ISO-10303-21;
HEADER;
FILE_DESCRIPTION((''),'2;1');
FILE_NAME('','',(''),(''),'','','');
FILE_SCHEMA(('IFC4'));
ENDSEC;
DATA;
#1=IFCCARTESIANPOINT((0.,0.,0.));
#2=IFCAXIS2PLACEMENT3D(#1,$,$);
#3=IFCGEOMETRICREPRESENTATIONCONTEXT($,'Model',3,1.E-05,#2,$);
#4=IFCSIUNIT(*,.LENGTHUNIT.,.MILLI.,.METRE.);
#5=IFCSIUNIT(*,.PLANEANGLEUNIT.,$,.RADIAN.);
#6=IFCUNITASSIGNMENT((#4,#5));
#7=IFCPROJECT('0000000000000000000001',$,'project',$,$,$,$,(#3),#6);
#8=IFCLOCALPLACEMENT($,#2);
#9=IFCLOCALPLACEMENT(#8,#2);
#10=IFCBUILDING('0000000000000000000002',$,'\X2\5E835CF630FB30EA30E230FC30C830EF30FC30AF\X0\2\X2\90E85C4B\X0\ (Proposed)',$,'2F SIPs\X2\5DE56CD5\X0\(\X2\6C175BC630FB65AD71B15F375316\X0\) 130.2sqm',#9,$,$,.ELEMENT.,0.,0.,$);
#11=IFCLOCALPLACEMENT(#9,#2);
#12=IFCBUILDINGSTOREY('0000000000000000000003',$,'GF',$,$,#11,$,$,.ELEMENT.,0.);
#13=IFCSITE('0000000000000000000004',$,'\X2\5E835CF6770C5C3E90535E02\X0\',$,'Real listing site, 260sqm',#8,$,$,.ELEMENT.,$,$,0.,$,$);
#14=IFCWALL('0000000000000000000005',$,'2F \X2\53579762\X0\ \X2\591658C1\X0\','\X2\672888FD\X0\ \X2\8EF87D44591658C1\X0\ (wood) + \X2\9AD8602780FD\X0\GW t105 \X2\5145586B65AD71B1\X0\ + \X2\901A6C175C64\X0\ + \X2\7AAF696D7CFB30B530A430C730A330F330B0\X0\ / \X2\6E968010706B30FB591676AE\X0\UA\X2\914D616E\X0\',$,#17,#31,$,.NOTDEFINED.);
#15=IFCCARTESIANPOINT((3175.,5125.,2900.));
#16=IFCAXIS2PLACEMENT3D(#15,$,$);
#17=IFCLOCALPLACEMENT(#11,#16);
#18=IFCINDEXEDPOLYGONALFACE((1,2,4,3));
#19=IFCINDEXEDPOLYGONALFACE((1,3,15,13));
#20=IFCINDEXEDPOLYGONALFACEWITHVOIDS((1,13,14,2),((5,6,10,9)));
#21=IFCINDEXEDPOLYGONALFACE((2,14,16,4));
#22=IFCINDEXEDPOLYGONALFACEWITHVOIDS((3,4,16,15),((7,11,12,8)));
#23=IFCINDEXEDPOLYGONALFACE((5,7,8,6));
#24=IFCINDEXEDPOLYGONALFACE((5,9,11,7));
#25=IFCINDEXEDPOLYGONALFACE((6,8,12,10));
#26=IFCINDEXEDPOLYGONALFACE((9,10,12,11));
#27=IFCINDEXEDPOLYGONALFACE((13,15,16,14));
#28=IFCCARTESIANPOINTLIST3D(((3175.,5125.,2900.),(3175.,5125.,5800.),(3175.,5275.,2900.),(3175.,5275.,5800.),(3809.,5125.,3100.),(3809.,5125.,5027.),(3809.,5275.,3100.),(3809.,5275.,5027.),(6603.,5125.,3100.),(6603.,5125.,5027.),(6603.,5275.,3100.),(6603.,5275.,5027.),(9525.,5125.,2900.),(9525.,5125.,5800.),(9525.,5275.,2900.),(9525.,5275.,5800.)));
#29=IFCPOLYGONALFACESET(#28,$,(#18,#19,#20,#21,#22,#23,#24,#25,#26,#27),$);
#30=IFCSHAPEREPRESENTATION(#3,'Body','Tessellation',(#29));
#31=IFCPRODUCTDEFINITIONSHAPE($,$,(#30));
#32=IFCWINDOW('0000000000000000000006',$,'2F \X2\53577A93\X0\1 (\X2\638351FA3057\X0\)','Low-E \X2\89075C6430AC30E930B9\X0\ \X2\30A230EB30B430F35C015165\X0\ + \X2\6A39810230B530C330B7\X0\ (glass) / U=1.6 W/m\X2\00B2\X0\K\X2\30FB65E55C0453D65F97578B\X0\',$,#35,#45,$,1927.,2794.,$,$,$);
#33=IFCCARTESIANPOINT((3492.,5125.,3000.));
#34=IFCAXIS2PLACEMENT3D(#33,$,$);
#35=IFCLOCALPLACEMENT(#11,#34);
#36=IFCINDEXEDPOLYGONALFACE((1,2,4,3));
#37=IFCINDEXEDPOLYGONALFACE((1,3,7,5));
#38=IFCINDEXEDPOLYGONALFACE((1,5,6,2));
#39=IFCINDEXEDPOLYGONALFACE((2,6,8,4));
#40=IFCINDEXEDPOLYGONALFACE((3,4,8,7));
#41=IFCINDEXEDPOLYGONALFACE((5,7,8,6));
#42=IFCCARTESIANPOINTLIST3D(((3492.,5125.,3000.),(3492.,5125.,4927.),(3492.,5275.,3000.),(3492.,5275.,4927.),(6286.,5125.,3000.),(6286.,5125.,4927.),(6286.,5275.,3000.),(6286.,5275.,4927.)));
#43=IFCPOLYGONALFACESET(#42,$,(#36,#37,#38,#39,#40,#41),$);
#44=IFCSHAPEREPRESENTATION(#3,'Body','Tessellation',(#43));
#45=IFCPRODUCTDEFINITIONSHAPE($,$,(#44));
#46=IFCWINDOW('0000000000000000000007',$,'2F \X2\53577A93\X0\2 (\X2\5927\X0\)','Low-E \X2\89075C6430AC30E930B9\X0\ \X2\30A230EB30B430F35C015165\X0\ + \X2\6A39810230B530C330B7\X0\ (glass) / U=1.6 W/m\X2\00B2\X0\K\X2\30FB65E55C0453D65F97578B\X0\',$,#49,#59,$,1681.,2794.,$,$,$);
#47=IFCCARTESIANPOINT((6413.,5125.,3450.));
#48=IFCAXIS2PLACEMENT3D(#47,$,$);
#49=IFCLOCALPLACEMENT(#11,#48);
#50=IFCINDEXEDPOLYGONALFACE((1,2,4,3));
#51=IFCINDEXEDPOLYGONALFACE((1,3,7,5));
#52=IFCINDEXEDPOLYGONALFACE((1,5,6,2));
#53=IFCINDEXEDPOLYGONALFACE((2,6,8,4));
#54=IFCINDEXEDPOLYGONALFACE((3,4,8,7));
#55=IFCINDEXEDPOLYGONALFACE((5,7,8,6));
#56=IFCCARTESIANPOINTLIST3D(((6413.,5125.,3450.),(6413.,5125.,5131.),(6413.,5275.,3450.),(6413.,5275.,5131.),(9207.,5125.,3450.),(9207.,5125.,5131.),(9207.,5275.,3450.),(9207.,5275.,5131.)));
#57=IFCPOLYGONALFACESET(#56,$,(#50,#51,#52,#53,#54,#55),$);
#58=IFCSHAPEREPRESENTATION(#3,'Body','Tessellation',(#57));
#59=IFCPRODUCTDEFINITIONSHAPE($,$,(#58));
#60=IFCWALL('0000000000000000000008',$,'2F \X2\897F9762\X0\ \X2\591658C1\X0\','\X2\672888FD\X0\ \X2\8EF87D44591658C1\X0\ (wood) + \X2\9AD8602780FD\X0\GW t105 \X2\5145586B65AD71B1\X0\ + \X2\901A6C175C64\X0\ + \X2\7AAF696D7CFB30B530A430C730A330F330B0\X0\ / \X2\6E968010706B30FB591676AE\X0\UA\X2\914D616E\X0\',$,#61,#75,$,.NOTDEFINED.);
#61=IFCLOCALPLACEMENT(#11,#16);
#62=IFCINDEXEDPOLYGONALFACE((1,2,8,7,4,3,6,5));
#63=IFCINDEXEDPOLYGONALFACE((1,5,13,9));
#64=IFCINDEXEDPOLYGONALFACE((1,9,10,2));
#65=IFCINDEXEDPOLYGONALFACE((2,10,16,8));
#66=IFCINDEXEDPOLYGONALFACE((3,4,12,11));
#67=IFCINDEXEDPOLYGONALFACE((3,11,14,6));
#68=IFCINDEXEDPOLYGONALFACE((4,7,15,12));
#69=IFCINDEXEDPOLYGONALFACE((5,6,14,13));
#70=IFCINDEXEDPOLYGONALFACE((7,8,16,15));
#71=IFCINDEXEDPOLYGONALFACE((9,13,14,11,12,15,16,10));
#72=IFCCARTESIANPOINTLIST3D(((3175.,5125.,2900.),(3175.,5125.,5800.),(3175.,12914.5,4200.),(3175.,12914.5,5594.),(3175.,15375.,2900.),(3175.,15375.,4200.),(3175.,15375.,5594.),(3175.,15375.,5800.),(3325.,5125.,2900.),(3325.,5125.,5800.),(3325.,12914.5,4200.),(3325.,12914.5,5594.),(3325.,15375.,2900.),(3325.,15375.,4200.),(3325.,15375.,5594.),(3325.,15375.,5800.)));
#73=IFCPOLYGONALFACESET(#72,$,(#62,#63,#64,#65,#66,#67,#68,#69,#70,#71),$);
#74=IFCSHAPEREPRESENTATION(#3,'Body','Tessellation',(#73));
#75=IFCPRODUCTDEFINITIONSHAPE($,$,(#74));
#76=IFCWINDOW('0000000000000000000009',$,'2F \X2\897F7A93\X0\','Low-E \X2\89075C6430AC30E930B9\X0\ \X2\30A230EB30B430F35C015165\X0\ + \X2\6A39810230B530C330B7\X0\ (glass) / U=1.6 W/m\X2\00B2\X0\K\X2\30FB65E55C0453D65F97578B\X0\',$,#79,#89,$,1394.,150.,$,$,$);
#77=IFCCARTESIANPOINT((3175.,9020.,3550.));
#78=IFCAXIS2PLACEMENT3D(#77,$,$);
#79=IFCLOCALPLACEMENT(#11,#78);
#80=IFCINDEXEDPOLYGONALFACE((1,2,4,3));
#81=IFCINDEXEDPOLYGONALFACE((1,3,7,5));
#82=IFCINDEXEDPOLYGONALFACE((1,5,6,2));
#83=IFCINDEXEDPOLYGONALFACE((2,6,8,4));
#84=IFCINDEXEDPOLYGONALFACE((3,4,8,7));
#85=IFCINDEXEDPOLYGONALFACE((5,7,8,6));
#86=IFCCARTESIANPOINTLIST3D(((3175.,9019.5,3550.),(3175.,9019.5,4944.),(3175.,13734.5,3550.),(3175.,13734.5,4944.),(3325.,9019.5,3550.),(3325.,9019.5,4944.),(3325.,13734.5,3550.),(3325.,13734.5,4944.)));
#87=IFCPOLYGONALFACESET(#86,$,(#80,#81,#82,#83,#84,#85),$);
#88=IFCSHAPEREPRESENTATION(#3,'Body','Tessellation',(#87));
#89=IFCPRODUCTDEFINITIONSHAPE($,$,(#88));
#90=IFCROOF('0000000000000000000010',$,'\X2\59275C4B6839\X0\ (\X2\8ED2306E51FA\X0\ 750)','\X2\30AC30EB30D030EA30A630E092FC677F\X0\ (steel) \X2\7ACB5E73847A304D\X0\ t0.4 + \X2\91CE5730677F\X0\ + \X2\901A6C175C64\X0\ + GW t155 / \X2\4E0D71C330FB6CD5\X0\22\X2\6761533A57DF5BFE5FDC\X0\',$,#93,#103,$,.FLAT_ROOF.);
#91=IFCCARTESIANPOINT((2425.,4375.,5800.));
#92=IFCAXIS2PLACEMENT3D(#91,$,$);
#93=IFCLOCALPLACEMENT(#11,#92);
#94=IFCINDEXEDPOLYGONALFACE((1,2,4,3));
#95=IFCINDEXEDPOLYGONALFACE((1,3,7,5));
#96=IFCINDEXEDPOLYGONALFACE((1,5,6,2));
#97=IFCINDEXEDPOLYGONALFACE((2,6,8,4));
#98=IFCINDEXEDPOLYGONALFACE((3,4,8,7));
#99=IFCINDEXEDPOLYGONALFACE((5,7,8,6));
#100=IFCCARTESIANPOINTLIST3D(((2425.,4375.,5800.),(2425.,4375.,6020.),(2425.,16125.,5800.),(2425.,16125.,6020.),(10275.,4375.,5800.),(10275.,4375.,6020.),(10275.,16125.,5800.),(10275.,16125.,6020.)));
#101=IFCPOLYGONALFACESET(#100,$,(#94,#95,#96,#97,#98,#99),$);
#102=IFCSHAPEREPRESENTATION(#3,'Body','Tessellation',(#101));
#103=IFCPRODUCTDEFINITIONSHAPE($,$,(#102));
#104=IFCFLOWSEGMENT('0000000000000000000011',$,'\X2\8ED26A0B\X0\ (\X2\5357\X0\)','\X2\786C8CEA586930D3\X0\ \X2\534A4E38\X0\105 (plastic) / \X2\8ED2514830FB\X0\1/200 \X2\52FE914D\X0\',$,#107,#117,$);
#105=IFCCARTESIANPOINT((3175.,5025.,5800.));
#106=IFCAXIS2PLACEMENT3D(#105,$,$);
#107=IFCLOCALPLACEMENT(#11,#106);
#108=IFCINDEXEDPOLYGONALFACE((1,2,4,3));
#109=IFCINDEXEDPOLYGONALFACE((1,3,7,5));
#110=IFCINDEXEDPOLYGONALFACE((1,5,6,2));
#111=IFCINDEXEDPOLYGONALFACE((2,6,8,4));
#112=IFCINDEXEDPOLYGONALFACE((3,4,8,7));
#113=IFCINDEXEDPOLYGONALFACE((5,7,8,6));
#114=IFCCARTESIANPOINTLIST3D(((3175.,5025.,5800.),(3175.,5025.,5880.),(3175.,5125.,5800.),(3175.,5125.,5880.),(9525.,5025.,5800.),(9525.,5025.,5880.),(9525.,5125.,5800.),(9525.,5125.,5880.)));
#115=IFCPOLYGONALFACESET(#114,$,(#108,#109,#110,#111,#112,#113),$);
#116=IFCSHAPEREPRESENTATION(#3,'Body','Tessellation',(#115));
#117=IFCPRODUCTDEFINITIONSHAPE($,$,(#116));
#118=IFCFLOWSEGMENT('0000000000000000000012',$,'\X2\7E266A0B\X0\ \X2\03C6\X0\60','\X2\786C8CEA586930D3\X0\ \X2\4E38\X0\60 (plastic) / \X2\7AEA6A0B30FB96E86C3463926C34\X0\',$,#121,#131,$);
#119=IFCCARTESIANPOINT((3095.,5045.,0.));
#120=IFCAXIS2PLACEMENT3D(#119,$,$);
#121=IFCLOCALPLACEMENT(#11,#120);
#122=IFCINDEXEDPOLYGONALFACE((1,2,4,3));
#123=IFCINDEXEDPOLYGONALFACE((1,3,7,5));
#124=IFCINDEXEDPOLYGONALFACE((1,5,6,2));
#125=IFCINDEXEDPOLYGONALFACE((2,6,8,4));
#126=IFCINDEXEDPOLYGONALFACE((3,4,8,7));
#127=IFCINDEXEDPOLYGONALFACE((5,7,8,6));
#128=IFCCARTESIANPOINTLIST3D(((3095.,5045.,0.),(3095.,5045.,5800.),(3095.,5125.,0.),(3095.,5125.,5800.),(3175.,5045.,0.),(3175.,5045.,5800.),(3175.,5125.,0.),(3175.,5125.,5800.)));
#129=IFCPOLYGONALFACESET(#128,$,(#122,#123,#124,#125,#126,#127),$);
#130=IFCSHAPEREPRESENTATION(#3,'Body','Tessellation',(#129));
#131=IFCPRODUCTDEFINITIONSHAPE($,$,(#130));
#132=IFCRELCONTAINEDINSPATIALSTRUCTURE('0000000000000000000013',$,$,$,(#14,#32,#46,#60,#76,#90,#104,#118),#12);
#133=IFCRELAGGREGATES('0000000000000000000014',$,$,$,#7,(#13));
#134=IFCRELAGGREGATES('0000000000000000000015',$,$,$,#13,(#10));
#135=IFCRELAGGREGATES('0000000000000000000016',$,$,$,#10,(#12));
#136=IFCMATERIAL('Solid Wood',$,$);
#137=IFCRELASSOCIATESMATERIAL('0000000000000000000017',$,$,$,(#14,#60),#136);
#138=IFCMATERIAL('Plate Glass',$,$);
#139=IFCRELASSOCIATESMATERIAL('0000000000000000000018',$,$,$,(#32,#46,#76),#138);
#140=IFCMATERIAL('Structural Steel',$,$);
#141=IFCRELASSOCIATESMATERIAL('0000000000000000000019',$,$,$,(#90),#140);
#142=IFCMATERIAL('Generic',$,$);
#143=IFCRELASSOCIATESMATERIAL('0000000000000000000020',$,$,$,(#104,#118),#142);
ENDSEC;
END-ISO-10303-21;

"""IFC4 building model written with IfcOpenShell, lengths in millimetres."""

from ifc_helpers import new_model, si_unit, frame, frame_2d, origin, place, context, project, spatial, rectangle, extrude, material, element, fill, save


model = new_model("IFC4")

# Units and contexts
model_context = context("Model", 3, precision=1e-05, world=origin())
ifc_project = project(units=[si_unit("LENGTHUNIT", "METRE", prefix="MILLI"), si_unit("PLANEANGLEUNIT", "RADIAN")], contexts=[model_context])

# Site, building, storey
site_placement = place(None, origin())
site = spatial("IfcSite", under=ifc_project, at=site_placement, Name="広島県尾道市", ObjectType="Real listing site, 260sqm", CompositionType="ELEMENT", RefElevation=0.0)
building_placement = place(site_placement, origin())
building = spatial("IfcBuilding", under=site, at=building_placement, Name="広島・リモートワーク2部屋 (Proposed)", ObjectType="2F SIPs工法(気密・断熱強化) 130.2sqm", CompositionType="ELEMENT", ElevationOfRefHeight=0.0, ElevationOfTerrain=0.0)
storey_placement = place(building_placement, origin())
storey = spatial("IfcBuildingStorey", under=building, at=storey_placement, Name="GF", CompositionType="ELEMENT", Elevation=0.0)

# Shared definitions
ifc_material_1 = material(Name="Solid Wood")

# Shared definitions
ifc_material_2 = material(Name="Plate Glass")

# Wall, openings, windows
wall_1_placement = place(storey_placement, frame((3175.0, 5125.0, 2900.0)))
wall_1 = element("IfcWall", 1, at=wall_1_placement, inside=storey, material=ifc_material_1, Name="2F 南面 外壁", Description="木製 軸組外壁 (wood) + 高性能GW t105 充填断熱 + 通気層 + 窯業系サイディング / 準耐火・外皮UA配慮", PredefinedType="NOTDEFINED", context=model_context, shape_type="SweptSolid", body=[
    extrude(rectangle(XDim=6350.0, YDim=150.0, at=frame_2d((3175.0, 75.0))), frame((3175.0, 5125.0, 2900.0)), (0.0, 0.0, 1.0), 2900.0),
])
opening_1_placement = place(storey_placement, frame((3492.0, 5125.0, 3000.0)))
opening_1 = element("IfcOpeningElement", 2, at=opening_1_placement, cuts=wall_1, PredefinedType="NOTDEFINED", context=model_context, shape_type="SweptSolid", body=[
    extrude(rectangle(XDim=2794.0, YDim=150.0, at=frame_2d((1397.0, 75.0))), frame((3492.0, 5125.0, 3000.0)), (0.0, 0.0, 1.0), 1927.0),
])
opening_2_placement = place(storey_placement, frame((6413.0, 5125.0, 3450.0)))
opening_2 = element("IfcOpeningElement", 3, at=opening_2_placement, cuts=wall_1, PredefinedType="NOTDEFINED", context=model_context, shape_type="SweptSolid", body=[
    extrude(rectangle(XDim=2794.0, YDim=150.0, at=frame_2d((1397.0, 75.0))), frame((6413.0, 5125.0, 3450.0)), (0.0, 0.0, 1.0), 1681.0),
])
window_1_placement = place(storey_placement, frame((3492.0, 5125.0, 3000.0)))
window_1 = element("IfcWindow", 4, at=window_1_placement, inside=storey, material=ifc_material_2, Name="2F 南窓1 (掃出し)", Description="Low-E 複層ガラス アルゴン封入 + 樹脂サッシ (glass) / U=1.6 W/m²K・日射取得型", OverallHeight=1927.0, OverallWidth=2794.0, context=model_context, shape_type="SweptSolid", body=[
    extrude(rectangle(XDim=2794.0, YDim=150.0, at=frame_2d((1397.0, 75.0))), frame((3492.0, 5125.0, 3000.0)), (0.0, 0.0, 1.0), 1927.0),
])
fill(opening_1, window_1)
window_2_placement = place(storey_placement, frame((6413.0, 5125.0, 3450.0)))
window_2 = element("IfcWindow", 5, at=window_2_placement, inside=storey, material=ifc_material_2, Name="2F 南窓2 (大)", Description="Low-E 複層ガラス アルゴン封入 + 樹脂サッシ (glass) / U=1.6 W/m²K・日射取得型", OverallHeight=1681.0, OverallWidth=2794.0, context=model_context, shape_type="SweptSolid", body=[
    extrude(rectangle(XDim=2794.0, YDim=150.0, at=frame_2d((1397.0, 75.0))), frame((6413.0, 5125.0, 3450.0)), (0.0, 0.0, 1.0), 1681.0),
])
fill(opening_2, window_2)

# Wall, opening, window
wall_2_placement = place(storey_placement, frame((3175.0, 5125.0, 2900.0)))
wall_2 = element("IfcWall", 6, at=wall_2_placement, inside=storey, material=ifc_material_1, Name="2F 西面 外壁", Description="木製 軸組外壁 (wood) + 高性能GW t105 充填断熱 + 通気層 + 窯業系サイディング / 準耐火・外皮UA配慮", PredefinedType="NOTDEFINED", context=model_context, shape_type="SweptSolid", body=[
    extrude(rectangle(XDim=150.0, YDim=10250.0, at=frame_2d((75.0, 5125.0))), frame((3175.0, 5125.0, 2900.0)), (0.0, 0.0, 1.0), 2900.0),
])
opening_3_placement = place(storey_placement, frame((3175.0, 9020.0, 3550.0)))
opening_3 = element("IfcOpeningElement", 7, at=opening_3_placement, cuts=wall_2, PredefinedType="NOTDEFINED", context=model_context, shape_type="SweptSolid", body=[
    extrude(rectangle(XDim=150.0, YDim=4715.0, at=frame_2d((75.0, 2357.0))), frame((3175.0, 9020.0, 3550.0)), (0.0, 0.0, 1.0), 1394.0),
])
window_3_placement = place(storey_placement, frame((3175.0, 9020.0, 3550.0)))
window_3 = element("IfcWindow", 8, at=window_3_placement, inside=storey, material=ifc_material_2, Name="2F 西窓", Description="Low-E 複層ガラス アルゴン封入 + 樹脂サッシ (glass) / U=1.6 W/m²K・日射取得型", OverallHeight=1394.0, OverallWidth=150.0, context=model_context, shape_type="SweptSolid", body=[
    extrude(rectangle(XDim=150.0, YDim=4715.0, at=frame_2d((75.0, 2357.0))), frame((3175.0, 9020.0, 3550.0)), (0.0, 0.0, 1.0), 1394.0),
])
fill(opening_3, window_3)

# Roof
ifc_material_3 = material(Name="Structural Steel")
roof_placement = place(storey_placement, frame((2425.0, 4375.0, 5800.0)))
element("IfcRoof", 9, at=roof_placement, inside=storey, material=ifc_material_3, Name="大屋根 (軒の出 750)", Description="ガルバリウム鋼板 (steel) 立平葺き t0.4 + 野地板 + 通気層 + GW t155 / 不燃・法22条区域対応", PredefinedType="FLAT_ROOF", context=model_context, shape_type="SweptSolid", body=[
    extrude(rectangle(XDim=7850.0, YDim=11750.0, at=frame_2d((3925.0, 5875.0))), frame((2425.0, 4375.0, 5800.0)), (0.0, 0.0, 1.0), 220.0),
])

# Flow segments
ifc_material_4 = material(Name="Generic")
flow_segment_1_placement = place(storey_placement, frame((3175.0, 5025.0, 5800.0)))
element("IfcFlowSegment", 10, at=flow_segment_1_placement, inside=storey, material=ifc_material_4, Name="軒樋 (南)", Description="硬質塩ビ 半丸105 (plastic) / 軒先・1/200 勾配", context=model_context, shape_type="SweptSolid", body=[
    extrude(rectangle(XDim=6350.0, YDim=100.0, at=frame_2d((3175.0, 50.0))), frame((3175.0, 5025.0, 5800.0)), (0.0, 0.0, 1.0), 80.0),
])
flow_segment_2_placement = place(storey_placement, frame((3095.0, 5045.0, 0.0)))
element("IfcFlowSegment", 11, at=flow_segment_2_placement, inside=storey, material=ifc_material_4, Name="縦樋 φ60", Description="硬質塩ビ 丸60 (plastic) / 竪樋・雨水排水", context=model_context, shape_type="SweptSolid", body=[
    extrude(rectangle(XDim=80.0, YDim=80.0, at=frame_2d((40.0, 40.0))), frame((3095.0, 5045.0, 0.0)), (0.0, 0.0, 1.0), 5800.0),
])

save(model, "model.ifc")
